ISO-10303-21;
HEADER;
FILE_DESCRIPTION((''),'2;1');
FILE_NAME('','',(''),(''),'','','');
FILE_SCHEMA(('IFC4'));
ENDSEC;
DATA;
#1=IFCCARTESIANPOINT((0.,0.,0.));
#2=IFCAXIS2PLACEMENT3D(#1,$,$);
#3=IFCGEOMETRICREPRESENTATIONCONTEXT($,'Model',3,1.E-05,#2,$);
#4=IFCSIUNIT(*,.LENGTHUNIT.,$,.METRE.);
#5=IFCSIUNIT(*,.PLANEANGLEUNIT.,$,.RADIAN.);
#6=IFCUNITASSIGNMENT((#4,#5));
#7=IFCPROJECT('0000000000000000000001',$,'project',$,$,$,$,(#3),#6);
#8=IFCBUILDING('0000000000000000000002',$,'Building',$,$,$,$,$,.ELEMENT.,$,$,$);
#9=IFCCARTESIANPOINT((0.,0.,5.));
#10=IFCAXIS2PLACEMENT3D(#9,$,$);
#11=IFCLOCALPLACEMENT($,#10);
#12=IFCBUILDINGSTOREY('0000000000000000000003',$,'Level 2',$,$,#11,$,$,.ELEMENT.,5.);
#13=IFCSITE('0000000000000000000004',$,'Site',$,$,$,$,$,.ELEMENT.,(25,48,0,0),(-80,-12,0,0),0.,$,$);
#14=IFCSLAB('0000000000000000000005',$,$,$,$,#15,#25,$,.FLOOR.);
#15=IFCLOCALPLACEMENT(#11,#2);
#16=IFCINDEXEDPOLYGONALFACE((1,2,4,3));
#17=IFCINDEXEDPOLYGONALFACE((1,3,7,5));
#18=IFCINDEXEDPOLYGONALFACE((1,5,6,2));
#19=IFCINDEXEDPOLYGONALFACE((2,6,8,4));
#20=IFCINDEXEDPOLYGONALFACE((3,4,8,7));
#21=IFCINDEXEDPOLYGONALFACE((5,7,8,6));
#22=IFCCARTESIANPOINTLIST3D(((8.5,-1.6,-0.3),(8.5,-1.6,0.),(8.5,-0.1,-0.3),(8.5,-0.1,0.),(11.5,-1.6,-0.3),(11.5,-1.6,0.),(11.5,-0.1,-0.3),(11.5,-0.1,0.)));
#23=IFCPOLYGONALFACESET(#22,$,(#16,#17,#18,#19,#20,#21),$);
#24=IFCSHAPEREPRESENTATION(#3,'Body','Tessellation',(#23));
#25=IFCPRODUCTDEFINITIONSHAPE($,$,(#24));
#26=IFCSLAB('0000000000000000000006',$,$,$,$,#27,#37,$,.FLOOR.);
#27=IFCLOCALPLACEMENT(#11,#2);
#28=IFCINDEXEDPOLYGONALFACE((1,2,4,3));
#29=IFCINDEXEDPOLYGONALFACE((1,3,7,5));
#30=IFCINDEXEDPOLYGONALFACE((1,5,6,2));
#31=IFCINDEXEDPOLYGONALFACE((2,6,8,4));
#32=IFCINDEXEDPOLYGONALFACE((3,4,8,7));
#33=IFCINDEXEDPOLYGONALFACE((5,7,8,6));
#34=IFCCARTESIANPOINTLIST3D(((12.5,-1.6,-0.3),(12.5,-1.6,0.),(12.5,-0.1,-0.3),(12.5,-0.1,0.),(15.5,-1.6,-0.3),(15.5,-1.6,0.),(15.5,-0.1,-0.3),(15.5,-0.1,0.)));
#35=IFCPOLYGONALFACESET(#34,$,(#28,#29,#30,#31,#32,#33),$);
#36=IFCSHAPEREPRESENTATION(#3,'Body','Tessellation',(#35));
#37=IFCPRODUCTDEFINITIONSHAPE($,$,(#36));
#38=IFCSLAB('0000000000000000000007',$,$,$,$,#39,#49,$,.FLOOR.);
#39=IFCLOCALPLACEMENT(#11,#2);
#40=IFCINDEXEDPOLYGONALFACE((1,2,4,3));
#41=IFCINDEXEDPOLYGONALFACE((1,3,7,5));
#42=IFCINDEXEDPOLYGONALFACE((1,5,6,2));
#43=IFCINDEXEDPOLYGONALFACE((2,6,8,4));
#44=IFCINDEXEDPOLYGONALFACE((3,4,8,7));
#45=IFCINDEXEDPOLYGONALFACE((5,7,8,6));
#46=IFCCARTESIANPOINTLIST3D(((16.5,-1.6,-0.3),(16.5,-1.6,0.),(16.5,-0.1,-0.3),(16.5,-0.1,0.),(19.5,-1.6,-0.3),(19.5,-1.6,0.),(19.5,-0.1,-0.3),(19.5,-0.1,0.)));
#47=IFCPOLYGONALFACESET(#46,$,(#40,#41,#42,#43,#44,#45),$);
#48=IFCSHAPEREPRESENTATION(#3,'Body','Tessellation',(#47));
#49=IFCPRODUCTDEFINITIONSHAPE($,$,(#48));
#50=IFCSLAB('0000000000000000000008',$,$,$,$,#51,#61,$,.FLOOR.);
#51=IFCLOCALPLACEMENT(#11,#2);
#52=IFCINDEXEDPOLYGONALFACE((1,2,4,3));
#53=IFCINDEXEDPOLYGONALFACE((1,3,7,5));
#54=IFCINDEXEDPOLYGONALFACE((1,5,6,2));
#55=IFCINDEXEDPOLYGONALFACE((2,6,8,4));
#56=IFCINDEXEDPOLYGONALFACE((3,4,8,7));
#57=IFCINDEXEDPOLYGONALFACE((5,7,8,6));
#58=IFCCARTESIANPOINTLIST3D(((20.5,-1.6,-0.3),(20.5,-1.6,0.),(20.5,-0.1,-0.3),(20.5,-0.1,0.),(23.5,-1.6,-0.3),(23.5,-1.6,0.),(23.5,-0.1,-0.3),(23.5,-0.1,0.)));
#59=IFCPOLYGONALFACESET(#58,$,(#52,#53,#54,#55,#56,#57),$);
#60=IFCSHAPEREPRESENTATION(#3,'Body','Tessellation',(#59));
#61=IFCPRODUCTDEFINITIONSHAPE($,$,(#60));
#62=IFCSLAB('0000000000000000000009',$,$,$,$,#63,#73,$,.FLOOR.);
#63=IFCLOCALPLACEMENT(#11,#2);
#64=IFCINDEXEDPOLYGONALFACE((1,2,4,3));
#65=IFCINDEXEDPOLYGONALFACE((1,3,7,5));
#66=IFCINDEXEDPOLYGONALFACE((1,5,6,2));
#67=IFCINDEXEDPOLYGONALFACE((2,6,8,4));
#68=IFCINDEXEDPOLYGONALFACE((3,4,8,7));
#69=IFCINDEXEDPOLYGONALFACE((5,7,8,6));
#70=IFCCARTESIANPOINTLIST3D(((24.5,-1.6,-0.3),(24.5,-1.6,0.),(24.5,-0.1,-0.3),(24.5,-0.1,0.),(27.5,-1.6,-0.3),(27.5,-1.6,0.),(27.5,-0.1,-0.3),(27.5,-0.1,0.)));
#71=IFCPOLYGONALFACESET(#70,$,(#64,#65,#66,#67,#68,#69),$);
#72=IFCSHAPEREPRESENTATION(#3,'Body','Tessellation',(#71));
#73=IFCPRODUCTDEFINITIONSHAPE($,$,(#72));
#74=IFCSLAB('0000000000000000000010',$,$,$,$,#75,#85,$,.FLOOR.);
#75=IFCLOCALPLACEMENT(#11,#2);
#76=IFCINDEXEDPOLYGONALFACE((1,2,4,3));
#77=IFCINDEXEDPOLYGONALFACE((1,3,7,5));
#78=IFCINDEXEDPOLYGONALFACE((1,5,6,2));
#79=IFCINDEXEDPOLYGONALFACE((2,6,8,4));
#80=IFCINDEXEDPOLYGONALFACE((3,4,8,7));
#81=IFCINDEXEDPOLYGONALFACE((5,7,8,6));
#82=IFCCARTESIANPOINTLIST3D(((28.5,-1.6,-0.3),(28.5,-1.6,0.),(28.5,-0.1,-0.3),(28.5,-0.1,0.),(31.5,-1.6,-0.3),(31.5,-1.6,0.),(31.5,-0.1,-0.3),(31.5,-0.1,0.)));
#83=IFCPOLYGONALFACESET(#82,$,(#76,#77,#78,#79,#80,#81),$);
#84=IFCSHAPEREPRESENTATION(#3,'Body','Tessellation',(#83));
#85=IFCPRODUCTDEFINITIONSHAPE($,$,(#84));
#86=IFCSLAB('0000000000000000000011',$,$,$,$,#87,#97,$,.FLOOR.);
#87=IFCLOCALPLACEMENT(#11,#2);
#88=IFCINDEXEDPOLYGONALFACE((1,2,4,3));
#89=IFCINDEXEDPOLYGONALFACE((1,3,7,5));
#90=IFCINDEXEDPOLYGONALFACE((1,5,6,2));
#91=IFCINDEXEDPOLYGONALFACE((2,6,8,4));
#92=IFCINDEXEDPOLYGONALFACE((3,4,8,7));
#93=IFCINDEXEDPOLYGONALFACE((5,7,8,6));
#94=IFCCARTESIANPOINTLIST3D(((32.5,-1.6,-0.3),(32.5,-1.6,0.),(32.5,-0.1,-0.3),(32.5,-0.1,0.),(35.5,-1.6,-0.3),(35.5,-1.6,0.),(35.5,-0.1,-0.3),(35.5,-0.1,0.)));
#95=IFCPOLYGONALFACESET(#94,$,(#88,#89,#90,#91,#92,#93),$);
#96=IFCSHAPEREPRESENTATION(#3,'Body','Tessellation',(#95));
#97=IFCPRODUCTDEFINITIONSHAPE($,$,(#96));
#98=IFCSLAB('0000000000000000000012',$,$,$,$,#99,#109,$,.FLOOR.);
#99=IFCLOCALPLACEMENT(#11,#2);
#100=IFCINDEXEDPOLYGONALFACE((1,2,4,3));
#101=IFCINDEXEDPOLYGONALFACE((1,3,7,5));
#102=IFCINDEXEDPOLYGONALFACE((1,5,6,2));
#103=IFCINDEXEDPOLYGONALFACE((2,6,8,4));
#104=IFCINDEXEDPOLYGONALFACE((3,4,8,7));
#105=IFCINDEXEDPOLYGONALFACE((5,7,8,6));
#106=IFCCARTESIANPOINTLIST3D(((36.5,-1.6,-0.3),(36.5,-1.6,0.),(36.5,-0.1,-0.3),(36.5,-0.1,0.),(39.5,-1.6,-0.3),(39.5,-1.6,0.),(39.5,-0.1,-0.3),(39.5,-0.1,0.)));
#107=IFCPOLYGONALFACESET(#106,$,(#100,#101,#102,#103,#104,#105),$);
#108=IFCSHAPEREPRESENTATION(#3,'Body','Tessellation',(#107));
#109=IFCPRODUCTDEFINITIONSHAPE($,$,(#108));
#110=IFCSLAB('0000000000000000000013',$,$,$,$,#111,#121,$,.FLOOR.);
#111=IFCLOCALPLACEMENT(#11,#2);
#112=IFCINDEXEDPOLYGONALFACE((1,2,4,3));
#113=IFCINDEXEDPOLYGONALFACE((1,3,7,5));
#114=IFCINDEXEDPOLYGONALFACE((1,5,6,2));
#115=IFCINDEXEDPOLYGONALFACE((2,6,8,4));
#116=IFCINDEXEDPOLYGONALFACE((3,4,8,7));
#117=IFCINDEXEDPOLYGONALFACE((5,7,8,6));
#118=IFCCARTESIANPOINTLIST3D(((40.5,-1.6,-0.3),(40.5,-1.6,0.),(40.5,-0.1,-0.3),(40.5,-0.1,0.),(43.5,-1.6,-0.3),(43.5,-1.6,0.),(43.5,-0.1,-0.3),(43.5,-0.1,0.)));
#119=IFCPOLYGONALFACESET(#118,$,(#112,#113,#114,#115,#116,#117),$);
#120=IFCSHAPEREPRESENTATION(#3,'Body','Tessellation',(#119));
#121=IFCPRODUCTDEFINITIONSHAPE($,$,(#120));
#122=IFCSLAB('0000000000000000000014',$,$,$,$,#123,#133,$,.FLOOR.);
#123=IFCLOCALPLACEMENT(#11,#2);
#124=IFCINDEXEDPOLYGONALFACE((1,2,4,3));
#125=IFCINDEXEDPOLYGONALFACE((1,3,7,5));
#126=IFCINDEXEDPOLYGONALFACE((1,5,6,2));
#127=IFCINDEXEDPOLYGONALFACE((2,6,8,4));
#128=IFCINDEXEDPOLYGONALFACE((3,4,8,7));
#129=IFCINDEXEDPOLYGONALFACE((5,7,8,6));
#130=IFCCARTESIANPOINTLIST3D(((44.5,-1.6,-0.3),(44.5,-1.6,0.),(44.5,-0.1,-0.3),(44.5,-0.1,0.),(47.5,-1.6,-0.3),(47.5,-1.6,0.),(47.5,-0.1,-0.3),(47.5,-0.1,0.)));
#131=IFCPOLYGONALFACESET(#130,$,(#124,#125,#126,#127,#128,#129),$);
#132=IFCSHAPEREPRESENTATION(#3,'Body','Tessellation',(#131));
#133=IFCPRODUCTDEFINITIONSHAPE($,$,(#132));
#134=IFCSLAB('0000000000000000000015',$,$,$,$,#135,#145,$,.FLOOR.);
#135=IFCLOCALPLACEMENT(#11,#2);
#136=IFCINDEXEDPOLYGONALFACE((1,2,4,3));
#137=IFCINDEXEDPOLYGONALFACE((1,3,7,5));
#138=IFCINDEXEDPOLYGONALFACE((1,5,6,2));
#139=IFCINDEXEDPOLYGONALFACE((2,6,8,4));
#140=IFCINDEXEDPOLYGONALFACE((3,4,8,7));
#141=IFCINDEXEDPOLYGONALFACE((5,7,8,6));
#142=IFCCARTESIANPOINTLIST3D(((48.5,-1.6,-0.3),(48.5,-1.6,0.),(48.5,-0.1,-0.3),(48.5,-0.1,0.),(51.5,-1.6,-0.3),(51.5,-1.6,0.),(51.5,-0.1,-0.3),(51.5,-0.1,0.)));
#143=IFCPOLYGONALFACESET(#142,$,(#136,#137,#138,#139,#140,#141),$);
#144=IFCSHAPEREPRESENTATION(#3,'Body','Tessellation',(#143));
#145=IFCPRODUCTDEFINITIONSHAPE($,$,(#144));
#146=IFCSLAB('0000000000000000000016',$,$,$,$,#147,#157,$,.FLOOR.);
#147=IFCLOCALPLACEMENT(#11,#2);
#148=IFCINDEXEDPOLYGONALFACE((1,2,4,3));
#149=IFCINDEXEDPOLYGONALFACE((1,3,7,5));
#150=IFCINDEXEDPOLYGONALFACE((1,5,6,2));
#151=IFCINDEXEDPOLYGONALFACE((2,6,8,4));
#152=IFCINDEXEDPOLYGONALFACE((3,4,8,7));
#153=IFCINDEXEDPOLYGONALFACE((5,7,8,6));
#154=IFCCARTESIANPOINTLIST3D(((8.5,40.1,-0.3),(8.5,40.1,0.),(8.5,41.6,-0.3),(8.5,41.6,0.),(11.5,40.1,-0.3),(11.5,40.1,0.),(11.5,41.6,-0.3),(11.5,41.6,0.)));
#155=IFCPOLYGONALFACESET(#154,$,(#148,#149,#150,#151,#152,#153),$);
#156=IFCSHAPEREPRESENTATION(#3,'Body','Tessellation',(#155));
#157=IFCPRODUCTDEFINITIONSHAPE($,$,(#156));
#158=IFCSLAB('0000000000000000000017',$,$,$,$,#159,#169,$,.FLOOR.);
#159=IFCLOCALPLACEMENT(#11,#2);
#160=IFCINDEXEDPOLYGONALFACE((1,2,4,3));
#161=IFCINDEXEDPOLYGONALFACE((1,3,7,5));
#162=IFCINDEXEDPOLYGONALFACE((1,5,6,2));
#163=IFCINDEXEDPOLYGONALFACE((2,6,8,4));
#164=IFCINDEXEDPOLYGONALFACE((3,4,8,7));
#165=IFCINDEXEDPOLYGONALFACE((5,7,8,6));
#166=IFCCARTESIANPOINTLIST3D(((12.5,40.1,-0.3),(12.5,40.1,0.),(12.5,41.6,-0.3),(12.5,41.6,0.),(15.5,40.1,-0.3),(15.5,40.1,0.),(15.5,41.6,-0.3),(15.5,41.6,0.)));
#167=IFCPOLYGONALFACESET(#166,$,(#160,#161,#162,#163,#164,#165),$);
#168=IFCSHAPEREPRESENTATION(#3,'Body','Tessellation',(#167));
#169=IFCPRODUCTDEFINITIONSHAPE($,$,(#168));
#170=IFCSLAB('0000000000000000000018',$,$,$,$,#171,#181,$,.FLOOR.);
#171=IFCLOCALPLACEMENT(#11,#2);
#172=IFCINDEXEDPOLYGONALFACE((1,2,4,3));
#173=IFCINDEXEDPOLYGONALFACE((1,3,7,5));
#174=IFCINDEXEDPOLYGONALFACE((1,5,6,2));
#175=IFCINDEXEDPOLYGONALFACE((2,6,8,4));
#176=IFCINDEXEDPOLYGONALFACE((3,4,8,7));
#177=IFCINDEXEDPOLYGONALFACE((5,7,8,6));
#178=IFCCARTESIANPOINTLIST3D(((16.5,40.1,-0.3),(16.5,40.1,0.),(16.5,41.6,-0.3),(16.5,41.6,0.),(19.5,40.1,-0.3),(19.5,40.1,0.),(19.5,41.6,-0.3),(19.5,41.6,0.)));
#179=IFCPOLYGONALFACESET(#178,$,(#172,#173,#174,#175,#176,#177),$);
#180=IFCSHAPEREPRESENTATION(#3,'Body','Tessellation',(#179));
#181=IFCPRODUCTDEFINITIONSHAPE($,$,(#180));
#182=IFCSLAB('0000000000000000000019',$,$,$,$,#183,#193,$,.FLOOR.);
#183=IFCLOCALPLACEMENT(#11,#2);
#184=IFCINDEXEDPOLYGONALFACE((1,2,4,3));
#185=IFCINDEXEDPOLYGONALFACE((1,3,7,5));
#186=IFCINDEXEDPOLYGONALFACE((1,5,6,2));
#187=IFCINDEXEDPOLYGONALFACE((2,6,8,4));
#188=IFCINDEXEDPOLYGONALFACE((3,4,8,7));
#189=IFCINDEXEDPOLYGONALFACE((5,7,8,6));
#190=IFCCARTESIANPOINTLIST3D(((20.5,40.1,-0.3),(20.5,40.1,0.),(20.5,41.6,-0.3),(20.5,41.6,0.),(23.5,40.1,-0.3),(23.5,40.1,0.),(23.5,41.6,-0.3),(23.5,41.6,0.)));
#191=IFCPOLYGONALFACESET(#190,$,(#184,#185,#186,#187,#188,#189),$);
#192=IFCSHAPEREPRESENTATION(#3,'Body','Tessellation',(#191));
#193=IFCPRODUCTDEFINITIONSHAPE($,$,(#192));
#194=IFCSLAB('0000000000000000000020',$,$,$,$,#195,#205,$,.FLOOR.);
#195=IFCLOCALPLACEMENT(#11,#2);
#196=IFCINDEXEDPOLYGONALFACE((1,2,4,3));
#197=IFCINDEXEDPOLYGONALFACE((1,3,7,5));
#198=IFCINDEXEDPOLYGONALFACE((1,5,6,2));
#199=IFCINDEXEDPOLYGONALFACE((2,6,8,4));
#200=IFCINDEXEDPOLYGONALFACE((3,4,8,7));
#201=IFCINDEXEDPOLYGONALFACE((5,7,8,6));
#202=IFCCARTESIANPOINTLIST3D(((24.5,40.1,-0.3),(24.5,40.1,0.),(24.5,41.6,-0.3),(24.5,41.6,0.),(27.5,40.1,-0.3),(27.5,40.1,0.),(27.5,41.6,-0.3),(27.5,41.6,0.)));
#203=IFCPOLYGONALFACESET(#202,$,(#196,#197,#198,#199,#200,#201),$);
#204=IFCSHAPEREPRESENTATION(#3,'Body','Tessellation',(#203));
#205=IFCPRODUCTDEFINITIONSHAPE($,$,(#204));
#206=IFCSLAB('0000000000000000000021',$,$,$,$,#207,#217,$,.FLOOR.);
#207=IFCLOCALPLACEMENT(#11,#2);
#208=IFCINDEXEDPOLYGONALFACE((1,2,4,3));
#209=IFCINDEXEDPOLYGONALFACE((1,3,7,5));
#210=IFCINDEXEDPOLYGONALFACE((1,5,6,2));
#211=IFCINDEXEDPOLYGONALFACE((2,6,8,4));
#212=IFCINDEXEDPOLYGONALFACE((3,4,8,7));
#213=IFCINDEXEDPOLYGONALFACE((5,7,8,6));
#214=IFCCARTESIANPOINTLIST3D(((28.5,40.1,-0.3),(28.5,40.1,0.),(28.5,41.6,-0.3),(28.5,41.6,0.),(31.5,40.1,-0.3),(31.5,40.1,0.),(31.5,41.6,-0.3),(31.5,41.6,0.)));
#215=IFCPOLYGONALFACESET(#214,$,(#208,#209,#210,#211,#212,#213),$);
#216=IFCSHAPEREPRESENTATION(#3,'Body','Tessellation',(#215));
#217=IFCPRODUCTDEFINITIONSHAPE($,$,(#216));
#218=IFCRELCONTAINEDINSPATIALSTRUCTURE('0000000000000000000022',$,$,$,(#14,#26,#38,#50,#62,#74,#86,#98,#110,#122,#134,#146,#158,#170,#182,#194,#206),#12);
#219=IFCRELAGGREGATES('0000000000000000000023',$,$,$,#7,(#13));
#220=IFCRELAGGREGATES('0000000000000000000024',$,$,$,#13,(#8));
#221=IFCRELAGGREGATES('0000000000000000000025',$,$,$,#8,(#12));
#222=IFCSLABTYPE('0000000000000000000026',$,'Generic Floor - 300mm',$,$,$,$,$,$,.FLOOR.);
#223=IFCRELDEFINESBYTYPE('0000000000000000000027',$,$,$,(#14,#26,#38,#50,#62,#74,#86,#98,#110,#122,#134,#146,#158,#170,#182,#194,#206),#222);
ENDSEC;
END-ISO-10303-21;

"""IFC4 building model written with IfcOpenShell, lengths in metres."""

from ifc_helpers import new_model, si_unit, frame, origin, place, context, project, spatial, polyline, outline, extrude, type_object, element, save


model = new_model("IFC4")

# Units and contexts
model_context = context("Model", 3, precision=1e-05, world=origin())
ifc_project = project(units=[si_unit("LENGTHUNIT", "METRE"), si_unit("PLANEANGLEUNIT", "RADIAN")], contexts=[model_context])

# Site, building, storey
site = spatial("IfcSite", under=ifc_project, Name="Site", CompositionType="ELEMENT", RefLatitude=(25, 48, 0, 0), RefLongitude=(-80, -12, 0, 0), RefElevation=0.0)
building = spatial("IfcBuilding", under=site, Name="Building", CompositionType="ELEMENT")
storey_placement = place(None, frame((0.0, 0.0, 5.0)))
storey = spatial("IfcBuildingStorey", under=building, at=storey_placement, Name="Level 2", CompositionType="ELEMENT", Elevation=5.0)

# Slabs
slab_type = type_object("IfcSlabType", Name="Generic Floor - 300mm", PredefinedType="FLOOR")
slab_1_placement = place(None, frame((0.0, 0.0, 5.0)))
element("IfcSlab", 1, at=slab_1_placement, inside=storey, type_object=slab_type, PredefinedType="FLOOR", context=model_context, shape_type="SweptSolid", body=[
    extrude(outline(polyline([(11.5, -0.1), (8.5, -0.1), (8.5, -1.6), (11.5, -1.6), (11.5, -0.1)])), origin(), (0.0, 0.0, -1.0), 0.3),
])
slab_2_placement = place(None, frame((0.0, 0.0, 5.0)))
element("IfcSlab", 2, at=slab_2_placement, inside=storey, type_object=slab_type, PredefinedType="FLOOR", context=model_context, shape_type="SweptSolid", body=[
    extrude(outline(polyline([(12.5, -0.1), (12.5, -1.6), (15.5, -1.6), (15.5, -0.1), (12.5, -0.1)])), origin(), (0.0, 0.0, -1.0), 0.3),
])
slab_3_placement = place(None, frame((0.0, 0.0, 5.0)))
element("IfcSlab", 3, at=slab_3_placement, inside=storey, type_object=slab_type, PredefinedType="FLOOR", context=model_context, shape_type="SweptSolid", body=[
    extrude(outline(polyline([(19.5, -0.1), (16.5, -0.1), (16.5, -1.6), (19.5, -1.6), (19.5, -0.1)])), origin(), (0.0, 0.0, -1.0), 0.3),
])
slab_4_placement = place(None, frame((0.0, 0.0, 5.0)))
element("IfcSlab", 4, at=slab_4_placement, inside=storey, type_object=slab_type, PredefinedType="FLOOR", context=model_context, shape_type="SweptSolid", body=[
    extrude(outline(polyline([(20.5, -0.1), (20.5, -1.6), (23.5, -1.6), (23.5, -0.1), (20.5, -0.1)])), origin(), (0.0, 0.0, -1.0), 0.3),
])
slab_5_placement = place(None, frame((0.0, 0.0, 5.0)))
element("IfcSlab", 5, at=slab_5_placement, inside=storey, type_object=slab_type, PredefinedType="FLOOR", context=model_context, shape_type="SweptSolid", body=[
    extrude(outline(polyline([(27.5, -0.1), (24.5, -0.1), (24.5, -1.6), (27.5, -1.6), (27.5, -0.1)])), origin(), (0.0, 0.0, -1.0), 0.3),
])
slab_6_placement = place(None, frame((0.0, 0.0, 5.0)))
element("IfcSlab", 6, at=slab_6_placement, inside=storey, type_object=slab_type, PredefinedType="FLOOR", context=model_context, shape_type="SweptSolid", body=[
    extrude(outline(polyline([(28.5, -0.1), (28.5, -1.6), (31.5, -1.6), (31.5, -0.1), (28.5, -0.1)])), origin(), (0.0, 0.0, -1.0), 0.3),
])
slab_7_placement = place(None, frame((0.0, 0.0, 5.0)))
element("IfcSlab", 7, at=slab_7_placement, inside=storey, type_object=slab_type, PredefinedType="FLOOR", context=model_context, shape_type="SweptSolid", body=[
    extrude(outline(polyline([(35.5, -0.1), (32.5, -0.1), (32.5, -1.6), (35.5, -1.6), (35.5, -0.1)])), origin(), (0.0, 0.0, -1.0), 0.3),
])
slab_8_placement = place(None, frame((0.0, 0.0, 5.0)))
element("IfcSlab", 8, at=slab_8_placement, inside=storey, type_object=slab_type, PredefinedType="FLOOR", context=model_context, shape_type="SweptSolid", body=[
    extrude(outline(polyline([(36.5, -0.1), (36.5, -1.6), (39.5, -1.6), (39.5, -0.1), (36.5, -0.1)])), origin(), (0.0, 0.0, -1.0), 0.3),
])
slab_9_placement = place(None, frame((0.0, 0.0, 5.0)))
element("IfcSlab", 9, at=slab_9_placement, inside=storey, type_object=slab_type, PredefinedType="FLOOR", context=model_context, shape_type="SweptSolid", body=[
    extrude(outline(polyline([(43.5, -0.1), (40.5, -0.1), (40.5, -1.6), (43.5, -1.6), (43.5, -0.1)])), origin(), (0.0, 0.0, -1.0), 0.3),
])
slab_10_placement = place(None, frame((0.0, 0.0, 5.0)))
element("IfcSlab", 10, at=slab_10_placement, inside=storey, type_object=slab_type, PredefinedType="FLOOR", context=model_context, shape_type="SweptSolid", body=[
    extrude(outline(polyline([(44.5, -0.1), (44.5, -1.6), (47.5, -1.6), (47.5, -0.1), (44.5, -0.1)])), origin(), (0.0, 0.0, -1.0), 0.3),
])
slab_11_placement = place(None, frame((0.0, 0.0, 5.0)))
element("IfcSlab", 11, at=slab_11_placement, inside=storey, type_object=slab_type, PredefinedType="FLOOR", context=model_context, shape_type="SweptSolid", body=[
    extrude(outline(polyline([(51.5, -0.1), (48.5, -0.1), (48.5, -1.6), (51.5, -1.6), (51.5, -0.1)])), origin(), (0.0, 0.0, -1.0), 0.3),
])
slab_12_placement = place(None, frame((0.0, 0.0, 5.0)))
element("IfcSlab", 12, at=slab_12_placement, inside=storey, type_object=slab_type, PredefinedType="FLOOR", context=model_context, shape_type="SweptSolid", body=[
    extrude(outline(polyline([(8.5, 40.1), (11.5, 40.1), (11.5, 41.6), (8.5, 41.6), (8.5, 40.1)])), origin(), (0.0, 0.0, -1.0), 0.3),
])
slab_13_placement = place(None, frame((0.0, 0.0, 5.0)))
element("IfcSlab", 13, at=slab_13_placement, inside=storey, type_object=slab_type, PredefinedType="FLOOR", context=model_context, shape_type="SweptSolid", body=[
    extrude(outline(polyline([(15.5, 40.1), (15.5, 41.6), (12.5, 41.6), (12.5, 40.1), (15.5, 40.1)])), origin(), (0.0, 0.0, -1.0), 0.3),
])
slab_14_placement = place(None, frame((0.0, 0.0, 5.0)))
element("IfcSlab", 14, at=slab_14_placement, inside=storey, type_object=slab_type, PredefinedType="FLOOR", context=model_context, shape_type="SweptSolid", body=[
    extrude(outline(polyline([(16.5, 40.1), (19.5, 40.1), (19.5, 41.6), (16.5, 41.6), (16.5, 40.1)])), origin(), (0.0, 0.0, -1.0), 0.3),
])
slab_15_placement = place(None, frame((0.0, 0.0, 5.0)))
element("IfcSlab", 15, at=slab_15_placement, inside=storey, type_object=slab_type, PredefinedType="FLOOR", context=model_context, shape_type="SweptSolid", body=[
    extrude(outline(polyline([(23.5, 40.1), (23.5, 41.6), (20.5, 41.6), (20.5, 40.1), (23.5, 40.1)])), origin(), (0.0, 0.0, -1.0), 0.3),
])
slab_16_placement = place(None, frame((0.0, 0.0, 5.0)))
element("IfcSlab", 16, at=slab_16_placement, inside=storey, type_object=slab_type, PredefinedType="FLOOR", context=model_context, shape_type="SweptSolid", body=[
    extrude(outline(polyline([(24.5, 40.1), (27.5, 40.1), (27.5, 41.6), (24.5, 41.6), (24.5, 40.1)])), origin(), (0.0, 0.0, -1.0), 0.3),
])
slab_17_placement = place(None, frame((0.0, 0.0, 5.0)))
element("IfcSlab", 17, at=slab_17_placement, inside=storey, type_object=slab_type, PredefinedType="FLOOR", context=model_context, shape_type="SweptSolid", body=[
    extrude(outline(polyline([(31.5, 40.1), (31.5, 41.6), (28.5, 41.6), (28.5, 40.1), (31.5, 40.1)])), origin(), (0.0, 0.0, -1.0), 0.3),
])

save(model, "model.ifc")
